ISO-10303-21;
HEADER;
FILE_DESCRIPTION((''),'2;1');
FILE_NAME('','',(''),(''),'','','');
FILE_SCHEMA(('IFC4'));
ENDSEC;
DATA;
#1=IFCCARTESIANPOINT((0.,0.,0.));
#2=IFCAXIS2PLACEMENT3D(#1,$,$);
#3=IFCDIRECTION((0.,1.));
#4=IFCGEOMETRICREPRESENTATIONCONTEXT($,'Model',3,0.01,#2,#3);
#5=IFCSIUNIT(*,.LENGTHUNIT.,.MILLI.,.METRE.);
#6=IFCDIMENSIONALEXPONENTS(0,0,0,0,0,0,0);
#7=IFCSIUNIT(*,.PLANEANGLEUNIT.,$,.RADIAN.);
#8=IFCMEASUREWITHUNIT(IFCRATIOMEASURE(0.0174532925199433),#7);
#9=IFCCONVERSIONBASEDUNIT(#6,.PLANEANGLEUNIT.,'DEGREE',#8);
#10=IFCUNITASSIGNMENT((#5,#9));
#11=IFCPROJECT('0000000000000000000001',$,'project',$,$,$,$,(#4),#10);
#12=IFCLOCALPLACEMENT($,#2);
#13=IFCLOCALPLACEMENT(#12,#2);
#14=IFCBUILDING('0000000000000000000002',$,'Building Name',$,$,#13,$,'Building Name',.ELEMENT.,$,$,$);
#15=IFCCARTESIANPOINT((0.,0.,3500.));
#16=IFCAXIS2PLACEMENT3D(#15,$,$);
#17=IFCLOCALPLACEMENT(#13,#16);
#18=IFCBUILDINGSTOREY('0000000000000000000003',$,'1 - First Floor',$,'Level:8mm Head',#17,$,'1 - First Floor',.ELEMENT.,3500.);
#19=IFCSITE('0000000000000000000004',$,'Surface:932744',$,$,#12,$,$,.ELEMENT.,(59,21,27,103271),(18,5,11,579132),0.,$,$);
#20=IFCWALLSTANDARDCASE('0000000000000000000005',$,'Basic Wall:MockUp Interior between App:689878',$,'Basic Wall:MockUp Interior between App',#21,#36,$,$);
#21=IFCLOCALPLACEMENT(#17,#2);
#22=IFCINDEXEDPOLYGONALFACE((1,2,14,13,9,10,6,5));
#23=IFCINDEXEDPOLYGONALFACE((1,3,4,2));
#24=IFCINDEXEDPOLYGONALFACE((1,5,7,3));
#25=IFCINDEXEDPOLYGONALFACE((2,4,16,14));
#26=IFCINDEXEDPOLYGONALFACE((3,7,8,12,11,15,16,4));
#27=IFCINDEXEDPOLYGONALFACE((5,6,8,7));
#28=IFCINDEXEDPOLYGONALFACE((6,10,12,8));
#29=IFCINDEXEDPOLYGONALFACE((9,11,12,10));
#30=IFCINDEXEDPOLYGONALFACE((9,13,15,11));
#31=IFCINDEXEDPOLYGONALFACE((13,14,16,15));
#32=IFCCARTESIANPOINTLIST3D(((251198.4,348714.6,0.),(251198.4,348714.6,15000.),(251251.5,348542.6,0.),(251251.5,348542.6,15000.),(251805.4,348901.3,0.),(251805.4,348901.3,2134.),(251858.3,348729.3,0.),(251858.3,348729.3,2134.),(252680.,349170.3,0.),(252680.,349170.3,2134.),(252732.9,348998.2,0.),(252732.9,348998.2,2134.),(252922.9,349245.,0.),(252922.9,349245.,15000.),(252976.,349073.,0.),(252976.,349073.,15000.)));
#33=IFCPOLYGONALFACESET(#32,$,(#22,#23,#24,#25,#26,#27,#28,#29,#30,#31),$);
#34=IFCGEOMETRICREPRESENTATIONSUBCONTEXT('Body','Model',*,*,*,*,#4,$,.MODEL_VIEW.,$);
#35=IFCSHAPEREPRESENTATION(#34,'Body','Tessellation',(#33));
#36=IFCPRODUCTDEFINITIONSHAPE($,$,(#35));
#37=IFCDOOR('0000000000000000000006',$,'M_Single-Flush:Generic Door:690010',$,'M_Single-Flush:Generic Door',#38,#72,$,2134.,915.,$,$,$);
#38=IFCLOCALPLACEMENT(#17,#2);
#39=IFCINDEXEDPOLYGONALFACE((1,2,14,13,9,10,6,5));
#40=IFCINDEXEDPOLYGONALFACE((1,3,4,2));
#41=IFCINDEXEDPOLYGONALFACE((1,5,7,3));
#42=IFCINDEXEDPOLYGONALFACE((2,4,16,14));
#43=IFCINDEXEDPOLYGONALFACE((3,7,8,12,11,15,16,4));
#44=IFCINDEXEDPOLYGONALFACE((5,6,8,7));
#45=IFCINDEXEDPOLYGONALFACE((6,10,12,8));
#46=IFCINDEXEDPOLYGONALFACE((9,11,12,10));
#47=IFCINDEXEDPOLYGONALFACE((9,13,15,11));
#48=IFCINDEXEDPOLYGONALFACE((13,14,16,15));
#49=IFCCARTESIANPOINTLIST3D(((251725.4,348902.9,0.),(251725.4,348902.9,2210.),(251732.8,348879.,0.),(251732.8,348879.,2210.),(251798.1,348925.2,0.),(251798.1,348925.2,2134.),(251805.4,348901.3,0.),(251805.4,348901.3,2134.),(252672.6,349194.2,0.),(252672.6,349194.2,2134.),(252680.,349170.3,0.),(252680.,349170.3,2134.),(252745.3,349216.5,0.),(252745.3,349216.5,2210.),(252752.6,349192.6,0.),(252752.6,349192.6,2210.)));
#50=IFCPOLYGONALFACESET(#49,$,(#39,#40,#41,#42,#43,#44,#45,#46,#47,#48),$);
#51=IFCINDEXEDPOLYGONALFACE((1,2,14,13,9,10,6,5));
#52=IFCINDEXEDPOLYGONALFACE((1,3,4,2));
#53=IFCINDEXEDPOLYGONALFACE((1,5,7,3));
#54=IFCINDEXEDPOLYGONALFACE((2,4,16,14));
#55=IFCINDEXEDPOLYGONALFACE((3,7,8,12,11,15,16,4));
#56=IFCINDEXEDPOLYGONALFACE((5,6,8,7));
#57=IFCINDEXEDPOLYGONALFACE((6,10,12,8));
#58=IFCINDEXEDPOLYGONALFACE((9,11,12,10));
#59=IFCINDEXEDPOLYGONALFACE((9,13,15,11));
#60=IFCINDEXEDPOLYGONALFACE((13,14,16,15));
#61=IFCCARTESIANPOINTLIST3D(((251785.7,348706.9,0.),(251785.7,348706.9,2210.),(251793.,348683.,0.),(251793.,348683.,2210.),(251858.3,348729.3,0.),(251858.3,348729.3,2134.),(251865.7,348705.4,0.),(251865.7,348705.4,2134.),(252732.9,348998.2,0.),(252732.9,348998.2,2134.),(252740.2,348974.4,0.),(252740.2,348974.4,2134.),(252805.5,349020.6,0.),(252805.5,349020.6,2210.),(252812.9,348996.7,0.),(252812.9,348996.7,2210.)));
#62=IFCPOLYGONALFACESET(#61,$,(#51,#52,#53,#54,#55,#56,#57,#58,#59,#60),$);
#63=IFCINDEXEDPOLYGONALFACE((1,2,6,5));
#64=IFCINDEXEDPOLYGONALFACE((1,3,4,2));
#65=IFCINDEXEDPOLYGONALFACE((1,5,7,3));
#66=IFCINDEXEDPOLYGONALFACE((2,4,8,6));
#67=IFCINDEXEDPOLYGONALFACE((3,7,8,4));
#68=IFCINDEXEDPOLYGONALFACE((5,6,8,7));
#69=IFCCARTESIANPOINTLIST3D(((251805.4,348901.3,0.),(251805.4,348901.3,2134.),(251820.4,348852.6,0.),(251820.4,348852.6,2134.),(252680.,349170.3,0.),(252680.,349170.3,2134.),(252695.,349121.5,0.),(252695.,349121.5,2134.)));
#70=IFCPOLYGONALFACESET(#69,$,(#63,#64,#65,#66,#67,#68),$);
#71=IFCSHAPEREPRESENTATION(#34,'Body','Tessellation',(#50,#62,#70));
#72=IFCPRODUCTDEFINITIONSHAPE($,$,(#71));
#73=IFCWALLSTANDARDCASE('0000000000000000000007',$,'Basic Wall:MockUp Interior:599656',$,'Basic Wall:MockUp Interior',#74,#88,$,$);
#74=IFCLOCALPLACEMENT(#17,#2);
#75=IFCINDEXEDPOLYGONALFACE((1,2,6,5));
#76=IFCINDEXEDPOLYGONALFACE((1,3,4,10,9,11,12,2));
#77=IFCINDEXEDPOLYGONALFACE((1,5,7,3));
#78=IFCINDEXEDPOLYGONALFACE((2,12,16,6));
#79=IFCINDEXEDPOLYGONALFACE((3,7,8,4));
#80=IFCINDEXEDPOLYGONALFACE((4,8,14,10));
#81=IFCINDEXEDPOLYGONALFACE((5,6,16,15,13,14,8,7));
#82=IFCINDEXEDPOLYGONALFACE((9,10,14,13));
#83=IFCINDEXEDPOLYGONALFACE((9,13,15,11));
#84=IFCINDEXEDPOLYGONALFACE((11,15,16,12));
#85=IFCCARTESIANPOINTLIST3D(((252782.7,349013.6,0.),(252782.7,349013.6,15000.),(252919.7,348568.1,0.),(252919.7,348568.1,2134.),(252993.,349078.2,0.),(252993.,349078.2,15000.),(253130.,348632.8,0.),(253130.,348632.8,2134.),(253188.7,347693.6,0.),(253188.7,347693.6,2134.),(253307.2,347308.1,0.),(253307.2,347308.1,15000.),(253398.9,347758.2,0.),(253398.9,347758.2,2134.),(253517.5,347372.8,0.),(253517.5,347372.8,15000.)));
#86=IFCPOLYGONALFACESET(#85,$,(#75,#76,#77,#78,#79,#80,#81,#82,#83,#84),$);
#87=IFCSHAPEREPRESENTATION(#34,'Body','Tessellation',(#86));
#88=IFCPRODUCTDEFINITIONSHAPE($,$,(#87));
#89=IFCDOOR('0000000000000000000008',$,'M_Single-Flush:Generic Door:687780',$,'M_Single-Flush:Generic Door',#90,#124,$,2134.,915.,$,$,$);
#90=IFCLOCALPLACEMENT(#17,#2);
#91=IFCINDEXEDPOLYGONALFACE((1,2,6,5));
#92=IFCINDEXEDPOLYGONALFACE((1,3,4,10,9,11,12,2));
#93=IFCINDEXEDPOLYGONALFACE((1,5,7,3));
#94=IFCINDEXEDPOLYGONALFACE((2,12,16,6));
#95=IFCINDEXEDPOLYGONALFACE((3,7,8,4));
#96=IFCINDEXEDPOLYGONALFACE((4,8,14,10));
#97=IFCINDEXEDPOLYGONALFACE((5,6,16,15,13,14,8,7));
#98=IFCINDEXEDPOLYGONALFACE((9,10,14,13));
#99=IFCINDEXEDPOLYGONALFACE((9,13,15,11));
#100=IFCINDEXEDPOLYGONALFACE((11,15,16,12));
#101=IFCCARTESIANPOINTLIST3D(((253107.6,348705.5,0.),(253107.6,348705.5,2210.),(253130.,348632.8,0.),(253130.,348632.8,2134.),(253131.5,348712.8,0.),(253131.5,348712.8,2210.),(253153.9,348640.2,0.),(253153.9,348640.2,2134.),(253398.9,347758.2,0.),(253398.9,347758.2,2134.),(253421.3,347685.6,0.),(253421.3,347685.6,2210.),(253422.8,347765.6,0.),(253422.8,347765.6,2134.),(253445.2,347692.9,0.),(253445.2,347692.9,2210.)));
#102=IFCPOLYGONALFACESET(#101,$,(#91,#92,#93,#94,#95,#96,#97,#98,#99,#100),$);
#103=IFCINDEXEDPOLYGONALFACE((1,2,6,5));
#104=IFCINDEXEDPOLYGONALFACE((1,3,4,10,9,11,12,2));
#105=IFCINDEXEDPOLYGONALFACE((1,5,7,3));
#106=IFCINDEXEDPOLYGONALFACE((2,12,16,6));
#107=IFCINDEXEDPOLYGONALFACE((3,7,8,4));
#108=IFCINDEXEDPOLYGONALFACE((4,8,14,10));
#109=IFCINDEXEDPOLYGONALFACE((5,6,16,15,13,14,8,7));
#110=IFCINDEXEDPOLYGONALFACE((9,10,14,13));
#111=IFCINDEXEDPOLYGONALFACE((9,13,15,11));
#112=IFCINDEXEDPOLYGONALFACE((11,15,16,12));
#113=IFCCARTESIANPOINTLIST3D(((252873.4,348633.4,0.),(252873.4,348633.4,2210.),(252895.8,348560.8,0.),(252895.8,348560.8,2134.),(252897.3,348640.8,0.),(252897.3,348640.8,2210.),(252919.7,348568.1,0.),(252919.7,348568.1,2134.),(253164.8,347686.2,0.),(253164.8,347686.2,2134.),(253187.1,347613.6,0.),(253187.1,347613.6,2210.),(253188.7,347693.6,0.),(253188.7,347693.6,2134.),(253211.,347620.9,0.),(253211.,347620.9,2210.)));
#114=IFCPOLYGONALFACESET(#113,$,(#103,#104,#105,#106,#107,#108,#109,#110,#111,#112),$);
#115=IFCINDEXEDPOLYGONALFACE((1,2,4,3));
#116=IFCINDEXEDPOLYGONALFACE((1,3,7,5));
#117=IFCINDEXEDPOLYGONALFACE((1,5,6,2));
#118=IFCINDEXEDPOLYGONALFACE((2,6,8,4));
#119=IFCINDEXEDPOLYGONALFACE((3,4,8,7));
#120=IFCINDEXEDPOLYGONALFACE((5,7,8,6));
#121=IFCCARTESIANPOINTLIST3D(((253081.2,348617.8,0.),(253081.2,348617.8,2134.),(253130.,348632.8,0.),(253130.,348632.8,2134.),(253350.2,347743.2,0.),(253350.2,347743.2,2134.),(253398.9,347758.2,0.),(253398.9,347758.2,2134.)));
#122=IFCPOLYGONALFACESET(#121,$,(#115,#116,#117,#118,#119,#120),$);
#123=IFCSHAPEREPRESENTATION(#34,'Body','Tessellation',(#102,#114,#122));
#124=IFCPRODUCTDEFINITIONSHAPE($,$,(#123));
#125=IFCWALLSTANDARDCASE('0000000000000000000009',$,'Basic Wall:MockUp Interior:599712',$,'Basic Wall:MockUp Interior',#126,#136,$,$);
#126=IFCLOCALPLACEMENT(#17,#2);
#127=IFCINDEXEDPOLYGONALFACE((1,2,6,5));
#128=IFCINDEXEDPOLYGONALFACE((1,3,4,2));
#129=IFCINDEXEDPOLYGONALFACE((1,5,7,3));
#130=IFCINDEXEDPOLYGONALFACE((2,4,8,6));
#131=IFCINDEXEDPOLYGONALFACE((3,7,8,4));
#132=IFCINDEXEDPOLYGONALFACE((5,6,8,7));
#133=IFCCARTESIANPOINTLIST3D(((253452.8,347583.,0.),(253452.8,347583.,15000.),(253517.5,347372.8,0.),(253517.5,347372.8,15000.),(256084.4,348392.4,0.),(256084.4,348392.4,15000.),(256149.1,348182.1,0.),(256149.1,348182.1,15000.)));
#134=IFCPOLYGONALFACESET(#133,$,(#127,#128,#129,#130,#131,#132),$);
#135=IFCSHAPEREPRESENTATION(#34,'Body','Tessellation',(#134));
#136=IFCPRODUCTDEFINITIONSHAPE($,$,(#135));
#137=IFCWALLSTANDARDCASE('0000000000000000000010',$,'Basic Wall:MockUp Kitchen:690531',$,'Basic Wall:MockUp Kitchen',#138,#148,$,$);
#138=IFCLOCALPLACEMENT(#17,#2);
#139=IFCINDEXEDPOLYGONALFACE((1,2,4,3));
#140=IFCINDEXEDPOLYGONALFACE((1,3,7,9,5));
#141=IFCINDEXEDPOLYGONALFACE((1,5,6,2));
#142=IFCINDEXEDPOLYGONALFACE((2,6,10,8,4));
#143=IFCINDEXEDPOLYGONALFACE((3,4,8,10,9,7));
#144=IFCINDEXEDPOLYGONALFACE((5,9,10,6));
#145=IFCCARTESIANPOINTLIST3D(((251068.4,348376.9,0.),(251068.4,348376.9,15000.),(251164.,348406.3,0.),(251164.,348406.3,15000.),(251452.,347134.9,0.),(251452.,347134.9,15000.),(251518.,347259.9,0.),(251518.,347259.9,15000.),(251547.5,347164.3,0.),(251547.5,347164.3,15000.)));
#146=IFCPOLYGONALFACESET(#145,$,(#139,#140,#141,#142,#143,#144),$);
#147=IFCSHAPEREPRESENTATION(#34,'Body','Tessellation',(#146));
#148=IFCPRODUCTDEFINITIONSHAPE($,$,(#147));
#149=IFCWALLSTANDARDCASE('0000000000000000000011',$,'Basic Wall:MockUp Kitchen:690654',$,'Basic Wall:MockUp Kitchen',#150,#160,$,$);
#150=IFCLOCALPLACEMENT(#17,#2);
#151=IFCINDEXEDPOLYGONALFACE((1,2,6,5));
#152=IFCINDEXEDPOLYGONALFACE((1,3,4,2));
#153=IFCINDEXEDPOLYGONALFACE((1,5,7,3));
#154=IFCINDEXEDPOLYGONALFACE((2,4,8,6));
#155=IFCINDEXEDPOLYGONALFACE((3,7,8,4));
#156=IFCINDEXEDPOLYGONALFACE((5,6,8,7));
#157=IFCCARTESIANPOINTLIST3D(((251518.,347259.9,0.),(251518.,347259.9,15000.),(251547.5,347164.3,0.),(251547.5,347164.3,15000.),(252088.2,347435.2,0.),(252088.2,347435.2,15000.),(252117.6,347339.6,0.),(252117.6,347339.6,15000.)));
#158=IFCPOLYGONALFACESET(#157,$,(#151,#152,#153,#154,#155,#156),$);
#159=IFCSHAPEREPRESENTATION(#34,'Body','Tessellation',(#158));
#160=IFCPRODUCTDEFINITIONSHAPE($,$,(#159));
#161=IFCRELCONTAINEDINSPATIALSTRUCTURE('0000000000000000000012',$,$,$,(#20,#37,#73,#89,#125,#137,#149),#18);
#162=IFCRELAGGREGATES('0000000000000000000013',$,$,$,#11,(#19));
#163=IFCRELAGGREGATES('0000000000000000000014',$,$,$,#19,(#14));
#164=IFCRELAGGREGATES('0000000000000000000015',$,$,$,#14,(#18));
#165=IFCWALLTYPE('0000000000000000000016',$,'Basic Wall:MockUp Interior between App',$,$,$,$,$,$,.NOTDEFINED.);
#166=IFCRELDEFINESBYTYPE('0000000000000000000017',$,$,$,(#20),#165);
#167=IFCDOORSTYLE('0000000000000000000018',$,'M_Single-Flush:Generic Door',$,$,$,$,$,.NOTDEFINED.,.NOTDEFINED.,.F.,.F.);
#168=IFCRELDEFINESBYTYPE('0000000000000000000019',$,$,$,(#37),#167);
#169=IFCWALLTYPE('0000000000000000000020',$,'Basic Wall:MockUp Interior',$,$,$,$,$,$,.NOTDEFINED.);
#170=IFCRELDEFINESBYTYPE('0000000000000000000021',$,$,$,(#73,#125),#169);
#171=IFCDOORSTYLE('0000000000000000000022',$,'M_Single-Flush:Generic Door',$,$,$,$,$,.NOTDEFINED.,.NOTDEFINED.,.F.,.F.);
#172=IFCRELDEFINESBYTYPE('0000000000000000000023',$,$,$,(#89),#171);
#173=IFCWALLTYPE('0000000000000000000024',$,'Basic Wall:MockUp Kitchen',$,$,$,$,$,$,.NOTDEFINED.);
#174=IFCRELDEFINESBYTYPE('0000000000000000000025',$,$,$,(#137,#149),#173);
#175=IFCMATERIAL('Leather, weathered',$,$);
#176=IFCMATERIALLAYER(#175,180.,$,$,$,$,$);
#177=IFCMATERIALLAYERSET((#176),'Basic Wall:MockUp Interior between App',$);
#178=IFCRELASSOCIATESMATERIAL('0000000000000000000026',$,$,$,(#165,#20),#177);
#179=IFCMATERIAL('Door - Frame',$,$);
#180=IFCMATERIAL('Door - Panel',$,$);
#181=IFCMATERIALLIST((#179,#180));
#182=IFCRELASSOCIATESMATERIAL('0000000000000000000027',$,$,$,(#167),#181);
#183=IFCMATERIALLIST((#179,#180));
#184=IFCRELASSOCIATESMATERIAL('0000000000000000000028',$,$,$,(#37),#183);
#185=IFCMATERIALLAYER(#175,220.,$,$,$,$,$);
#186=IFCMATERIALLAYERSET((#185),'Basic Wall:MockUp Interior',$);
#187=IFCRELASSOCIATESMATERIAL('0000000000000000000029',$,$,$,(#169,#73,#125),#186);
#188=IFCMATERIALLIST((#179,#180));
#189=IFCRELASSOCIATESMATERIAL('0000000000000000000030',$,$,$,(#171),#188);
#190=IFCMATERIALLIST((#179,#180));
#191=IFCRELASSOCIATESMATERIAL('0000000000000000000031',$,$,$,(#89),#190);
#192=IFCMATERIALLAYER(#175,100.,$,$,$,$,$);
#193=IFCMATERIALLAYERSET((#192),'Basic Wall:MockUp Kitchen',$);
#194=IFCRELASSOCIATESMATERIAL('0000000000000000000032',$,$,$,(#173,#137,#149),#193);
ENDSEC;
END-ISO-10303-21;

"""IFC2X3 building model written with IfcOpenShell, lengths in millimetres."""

from ifc_helpers import new_model, entity, si_unit, converted_unit, direction, frame, frame_2d, origin, place, context, subcontext, project, spatial, polyline, rectangle, outline, extrude, source, transform, mapped, material, material_list, layer, layer_set, layer_usage, type_object, type_shapes, element, fill, save


model = new_model("IFC2X3")

# Units and contexts
model_context = context("Model", 3, precision=0.01, world=origin(), true_north=direction((0.0, 1.0)))
body_context = subcontext(model_context, "Body", "Model", "MODEL_VIEW")
ifc_project = project(units=[si_unit("LENGTHUNIT", "METRE", prefix="MILLI"), converted_unit("PLANEANGLEUNIT", "DEGREE", entity("IfcRatioMeasure", 0.0174532925199433), si_unit("PLANEANGLEUNIT", "RADIAN"), dimensions=[0, 0, 0, 0, 0, 0, 0])], contexts=[model_context])

# Site, building, storey
site_placement = place(None, origin())
site = spatial("IfcSite", under=ifc_project, at=site_placement, Name="Surface:932744", CompositionType="ELEMENT", RefLatitude=(59, 21, 27, 103271), RefLongitude=(18, 5, 11, 579132), RefElevation=0.0)
building_placement = place(site_placement, origin())
building = spatial("IfcBuilding", under=site, at=building_placement, Name="Building Name", LongName="Building Name", CompositionType="ELEMENT")
storey_placement = place(building_placement, frame((0.0, 0.0, 3500.0)))
storey = spatial("IfcBuildingStorey", under=building, at=storey_placement, Name="1 - First Floor", ObjectType="Level:8mm Head", LongName="1 - First Floor", CompositionType="ELEMENT", Elevation=3500.0)

# Shared definitions
ifc_material_1 = material(Name="Leather, weathered")
ifc_layer_1 = layer(ifc_material_1, 180.0)
ifc_layer_set_1 = layer_set([ifc_layer_1], Name="Basic Wall:MockUp Interior between App")
wall_type_1 = type_object("IfcWallType", Name="Basic Wall:MockUp Interior between App", PredefinedType="NOTDEFINED", material=ifc_layer_set_1)

# Shared definitions
ifc_material_2 = material(Name="Door - Frame")
ifc_material_3 = material(Name="Door - Panel")
ifc_material_list_1 = material_list([ifc_material_2, ifc_material_3])
door_style_1 = type_object("IfcDoorStyle", Name="M_Single-Flush:Generic Door", ConstructionType="NOTDEFINED", OperationType="NOTDEFINED", ParameterTakesPrecedence=False, Sizeable=False, material=ifc_material_list_1)
shared_shape_1 = source(origin(), body_context, "Body", "SweptSolid", [
    extrude(outline(polyline([(-533.5, -1124.0), (533.5, -1124.0), (533.5, 1086.0), (457.5, 1086.0), (457.5, -1048.0), (-457.5, -1048.0), (-457.5, 1086.0), (-533.5, 1086.0), (-533.5, -1124.0)])), frame((457.5, 180.0, 1086.0), z_axis=(0.0, 1.0, 0.0), x_axis=(1.0, 0.0, 0.0)), (0.0, 0.0, 1.0), 25.0),
    extrude(outline(polyline([(-1124.0, -533.5), (1086.0, -533.5), (1086.0, -457.5), (-1048.0, -457.5), (-1048.0, 457.5), (1086.0, 457.5), (1086.0, 533.5), (-1124.0, 533.5), (-1124.0, -533.5)])), frame((457.5, -25.0, 1086.0), z_axis=(0.0, 1.0, 0.0), x_axis=(0.0, 0.0, -1.0)), (0.0, 0.0, 1.0), 25.0),
    extrude(rectangle(XDim=51.0, YDim=915.0, at=frame_2d((0.0, 0.0), x_axis=(1.0, 0.0))), frame((457.5, 154.5, 0.0), z_axis=(0.0, 0.0, 1.0), x_axis=(0.0, 1.0, 0.0)), (0.0, 0.0, 1.0), 2134.0),
])
type_shapes(door_style_1, [shared_shape_1])

# Walls, openings, doors
ifc_layer_usage_1 = layer_usage(ifc_layer_set_1, "AXIS2", "NEGATIVE", 90.0)
wall_1_placement = place(storey_placement, frame((251224.9, 348628.6, 0.0), z_axis=(0.0, 0.0, 1.0), x_axis=(0.955811, 0.29398, 0.0)))
wall_1 = element("IfcWallStandardCase", 1, at=wall_1_placement, inside=storey, type_object=wall_type_1, material=ifc_layer_usage_1, Name="Basic Wall:MockUp Interior between App:689878", ObjectType="Basic Wall:MockUp Interior between App", context=body_context, shape_type="SweptSolid", body=[
    extrude(outline(polyline([(0.2, -90.0), (1602.1, -90.0), (1804.4, -90.0), (1804.2, 90.0), (1624.2, 90.0), (0.0, 90.0), (0.2, -90.0)])), origin(), (0.0, 0.0, 1.0), 15000.0),
])
opening_1_placement = place(wall_1_placement, frame((635.0, -90.0, 0.0)))
opening_1 = element("IfcOpeningElement", 2, at=opening_1_placement, cuts=wall_1, ObjectType="Opening", context=body_context, shape_type="SweptSolid", body=[
    extrude(rectangle(XDim=915.0, YDim=2134.0, at=frame_2d((1067.0, 457.5), x_axis=(0.0, 1.0))), frame((0.0, 0.0, 0.0), z_axis=(0.0, 1.0, 0.0), x_axis=(0.0, 0.0, 1.0)), (0.0, 0.0, 1.0), 180.0),
])
ifc_material_list_2 = material_list([ifc_material_2, ifc_material_3])
door_1_placement = place(opening_1_placement, origin())
door_1 = element("IfcDoor", 3, at=door_1_placement, inside=storey, type_object=door_style_1, material=ifc_material_list_2, Name="M_Single-Flush:Generic Door:690010", ObjectType="M_Single-Flush:Generic Door", OverallHeight=2134.0, OverallWidth=915.0, context=body_context, shape_type="MappedRepresentation", body=[
    mapped(shared_shape_1, transform((0.0, 0.0, 0.0), scale=1.0)),
])
fill(opening_1, door_1)
ifc_layer_2 = layer(ifc_material_1, 220.0)
ifc_layer_set_2 = layer_set([ifc_layer_2], Name="Basic Wall:MockUp Interior")
ifc_layer_usage_2 = layer_usage(ifc_layer_set_2, "AXIS2", "NEGATIVE", 110.0)
wall_type_2 = type_object("IfcWallType", Name="Basic Wall:MockUp Interior", PredefinedType="NOTDEFINED", material=ifc_layer_set_2)
wall_2_placement = place(storey_placement, frame((252887.8, 349045.9, 0.0), z_axis=(0.0, 0.0, 1.0), x_axis=(0.29398, -0.955811, 0.0)))
wall_2 = element("IfcWallStandardCase", 4, at=wall_2_placement, inside=storey, type_object=wall_type_2, material=ifc_layer_usage_2, Name="Basic Wall:MockUp Interior:599656", ObjectType="Basic Wall:MockUp Interior", context=body_context, shape_type="SweptSolid", body=[
    extrude(rectangle(XDim=1784.3, YDim=220.0, at=frame_2d((892.2, 0.0), x_axis=(-1.0, 0.0))), origin(), (0.0, 0.0, 1.0), 15000.0),
])
opening_2_placement = place(wall_2_placement, frame((466.0, -110.0, 0.0)))
opening_2 = element("IfcOpeningElement", 5, at=opening_2_placement, cuts=wall_2, ObjectType="Opening", context=body_context, shape_type="SweptSolid", body=[
    extrude(rectangle(XDim=915.0, YDim=2134.0, at=frame_2d((1067.0, 457.5), x_axis=(0.0, 1.0))), frame((0.0, 0.0, 0.0), z_axis=(0.0, 1.0, 0.0), x_axis=(0.0, 0.0, 1.0)), (0.0, 0.0, 1.0), 220.0),
])
ifc_material_list_3 = material_list([ifc_material_2, ifc_material_3])
ifc_material_list_4 = material_list([ifc_material_2, ifc_material_3])
door_style_2 = type_object("IfcDoorStyle", Name="M_Single-Flush:Generic Door", ConstructionType="NOTDEFINED", OperationType="NOTDEFINED", ParameterTakesPrecedence=False, Sizeable=False, material=ifc_material_list_4)
shared_shape_2 = source(origin(), body_context, "Body", "SweptSolid", [
    extrude(outline(polyline([(-533.5, -1124.0), (533.5, -1124.0), (533.5, 1086.0), (457.5, 1086.0), (457.5, -1048.0), (-457.5, -1048.0), (-457.5, 1086.0), (-533.5, 1086.0), (-533.5, -1124.0)])), frame((457.5, 220.0, 1086.0), z_axis=(0.0, 1.0, 0.0), x_axis=(1.0, 0.0, 0.0)), (0.0, 0.0, 1.0), 25.0),
    extrude(outline(polyline([(-1124.0, -533.5), (1086.0, -533.5), (1086.0, -457.5), (-1048.0, -457.5), (-1048.0, 457.5), (1086.0, 457.5), (1086.0, 533.5), (-1124.0, 533.5), (-1124.0, -533.5)])), frame((457.5, -25.0, 1086.0), z_axis=(0.0, 1.0, 0.0), x_axis=(0.0, 0.0, -1.0)), (0.0, 0.0, 1.0), 25.0),
    extrude(rectangle(XDim=51.0, YDim=915.0, at=frame_2d((0.0, 0.0), x_axis=(1.0, 0.0))), frame((457.5, 194.5, 0.0), z_axis=(0.0, 0.0, 1.0), x_axis=(0.0, 1.0, 0.0)), (0.0, 0.0, 1.0), 2134.0),
])
type_shapes(door_style_2, [shared_shape_2])
door_2_placement = place(opening_2_placement, origin())
door_2 = element("IfcDoor", 6, at=door_2_placement, inside=storey, type_object=door_style_2, material=ifc_material_list_3, Name="M_Single-Flush:Generic Door:687780", ObjectType="M_Single-Flush:Generic Door", OverallHeight=2134.0, OverallWidth=915.0, context=body_context, shape_type="MappedRepresentation", body=[
    mapped(shared_shape_2, transform((0.0, 0.0, 0.0), scale=1.0)),
])
fill(opening_2, door_2)

# Walls
ifc_layer_usage_3 = layer_usage(ifc_layer_set_2, "AXIS2", "NEGATIVE", 110.0)
wall_3_placement = place(storey_placement, frame((253485.2, 347477.9, 0.0), z_axis=(0.0, 0.0, 1.0), x_axis=(0.955811, 0.29398, 0.0)))
element("IfcWallStandardCase", 7, at=wall_3_placement, inside=storey, type_object=wall_type_2, material=ifc_layer_usage_3, Name="Basic Wall:MockUp Interior:599712", ObjectType="Basic Wall:MockUp Interior", context=body_context, shape_type="SweptSolid", body=[
    extrude(rectangle(XDim=2753.2, YDim=220.0, at=frame_2d((1376.6, 0.0), x_axis=(-1.0, 0.0))), origin(), (0.0, 0.0, 1.0), 15000.0),
])
ifc_layer_3 = layer(ifc_material_1, 100.0)
ifc_layer_set_3 = layer_set([ifc_layer_3], Name="Basic Wall:MockUp Kitchen")
ifc_layer_usage_4 = layer_usage(ifc_layer_set_3, "AXIS2", "NEGATIVE", 50.0)
wall_type_3 = type_object("IfcWallType", Name="Basic Wall:MockUp Kitchen", PredefinedType="NOTDEFINED", material=ifc_layer_set_3)
wall_4_placement = place(storey_placement, frame((251499.8, 347149.6, 0.0), z_axis=(0.0, 0.0, 1.0), x_axis=(-0.29508, 0.955473, 0.0)))
element("IfcWallStandardCase", 8, at=wall_4_placement, inside=storey, type_object=wall_type_3, material=ifc_layer_usage_4, Name="Basic Wall:MockUp Kitchen:690531", ObjectType="Basic Wall:MockUp Kitchen", context=body_context, shape_type="SweptSolid", body=[
    extrude(outline(polyline([(1299.9, -50.0), (1300.0, 50.0), (0.1, 50.0), (0.0, -50.0), (100.0, -50.0), (1299.9, -50.0)])), origin(), (0.0, 0.0, 1.0), 15000.0),
])
ifc_layer_usage_5 = layer_usage(ifc_layer_set_3, "AXIS2", "NEGATIVE", 50.0)
wall_5_placement = place(storey_placement, frame((251532.7, 347212.1, 0.0), z_axis=(0.0, 0.0, 1.0), x_axis=(0.955818, 0.293958, 0.0)))
element("IfcWallStandardCase", 9, at=wall_5_placement, inside=storey, type_object=wall_type_3, material=ifc_layer_usage_5, Name="Basic Wall:MockUp Kitchen:690654", ObjectType="Basic Wall:MockUp Kitchen", context=body_context, shape_type="SweptSolid", body=[
    extrude(outline(polyline([(596.5, -50.0), (596.5, 50.0), (0.0, 50.0), (0.1, -50.0), (596.5, -50.0)])), origin(), (0.0, 0.0, 1.0), 15000.0),
])

save(model, "model.ifc")
